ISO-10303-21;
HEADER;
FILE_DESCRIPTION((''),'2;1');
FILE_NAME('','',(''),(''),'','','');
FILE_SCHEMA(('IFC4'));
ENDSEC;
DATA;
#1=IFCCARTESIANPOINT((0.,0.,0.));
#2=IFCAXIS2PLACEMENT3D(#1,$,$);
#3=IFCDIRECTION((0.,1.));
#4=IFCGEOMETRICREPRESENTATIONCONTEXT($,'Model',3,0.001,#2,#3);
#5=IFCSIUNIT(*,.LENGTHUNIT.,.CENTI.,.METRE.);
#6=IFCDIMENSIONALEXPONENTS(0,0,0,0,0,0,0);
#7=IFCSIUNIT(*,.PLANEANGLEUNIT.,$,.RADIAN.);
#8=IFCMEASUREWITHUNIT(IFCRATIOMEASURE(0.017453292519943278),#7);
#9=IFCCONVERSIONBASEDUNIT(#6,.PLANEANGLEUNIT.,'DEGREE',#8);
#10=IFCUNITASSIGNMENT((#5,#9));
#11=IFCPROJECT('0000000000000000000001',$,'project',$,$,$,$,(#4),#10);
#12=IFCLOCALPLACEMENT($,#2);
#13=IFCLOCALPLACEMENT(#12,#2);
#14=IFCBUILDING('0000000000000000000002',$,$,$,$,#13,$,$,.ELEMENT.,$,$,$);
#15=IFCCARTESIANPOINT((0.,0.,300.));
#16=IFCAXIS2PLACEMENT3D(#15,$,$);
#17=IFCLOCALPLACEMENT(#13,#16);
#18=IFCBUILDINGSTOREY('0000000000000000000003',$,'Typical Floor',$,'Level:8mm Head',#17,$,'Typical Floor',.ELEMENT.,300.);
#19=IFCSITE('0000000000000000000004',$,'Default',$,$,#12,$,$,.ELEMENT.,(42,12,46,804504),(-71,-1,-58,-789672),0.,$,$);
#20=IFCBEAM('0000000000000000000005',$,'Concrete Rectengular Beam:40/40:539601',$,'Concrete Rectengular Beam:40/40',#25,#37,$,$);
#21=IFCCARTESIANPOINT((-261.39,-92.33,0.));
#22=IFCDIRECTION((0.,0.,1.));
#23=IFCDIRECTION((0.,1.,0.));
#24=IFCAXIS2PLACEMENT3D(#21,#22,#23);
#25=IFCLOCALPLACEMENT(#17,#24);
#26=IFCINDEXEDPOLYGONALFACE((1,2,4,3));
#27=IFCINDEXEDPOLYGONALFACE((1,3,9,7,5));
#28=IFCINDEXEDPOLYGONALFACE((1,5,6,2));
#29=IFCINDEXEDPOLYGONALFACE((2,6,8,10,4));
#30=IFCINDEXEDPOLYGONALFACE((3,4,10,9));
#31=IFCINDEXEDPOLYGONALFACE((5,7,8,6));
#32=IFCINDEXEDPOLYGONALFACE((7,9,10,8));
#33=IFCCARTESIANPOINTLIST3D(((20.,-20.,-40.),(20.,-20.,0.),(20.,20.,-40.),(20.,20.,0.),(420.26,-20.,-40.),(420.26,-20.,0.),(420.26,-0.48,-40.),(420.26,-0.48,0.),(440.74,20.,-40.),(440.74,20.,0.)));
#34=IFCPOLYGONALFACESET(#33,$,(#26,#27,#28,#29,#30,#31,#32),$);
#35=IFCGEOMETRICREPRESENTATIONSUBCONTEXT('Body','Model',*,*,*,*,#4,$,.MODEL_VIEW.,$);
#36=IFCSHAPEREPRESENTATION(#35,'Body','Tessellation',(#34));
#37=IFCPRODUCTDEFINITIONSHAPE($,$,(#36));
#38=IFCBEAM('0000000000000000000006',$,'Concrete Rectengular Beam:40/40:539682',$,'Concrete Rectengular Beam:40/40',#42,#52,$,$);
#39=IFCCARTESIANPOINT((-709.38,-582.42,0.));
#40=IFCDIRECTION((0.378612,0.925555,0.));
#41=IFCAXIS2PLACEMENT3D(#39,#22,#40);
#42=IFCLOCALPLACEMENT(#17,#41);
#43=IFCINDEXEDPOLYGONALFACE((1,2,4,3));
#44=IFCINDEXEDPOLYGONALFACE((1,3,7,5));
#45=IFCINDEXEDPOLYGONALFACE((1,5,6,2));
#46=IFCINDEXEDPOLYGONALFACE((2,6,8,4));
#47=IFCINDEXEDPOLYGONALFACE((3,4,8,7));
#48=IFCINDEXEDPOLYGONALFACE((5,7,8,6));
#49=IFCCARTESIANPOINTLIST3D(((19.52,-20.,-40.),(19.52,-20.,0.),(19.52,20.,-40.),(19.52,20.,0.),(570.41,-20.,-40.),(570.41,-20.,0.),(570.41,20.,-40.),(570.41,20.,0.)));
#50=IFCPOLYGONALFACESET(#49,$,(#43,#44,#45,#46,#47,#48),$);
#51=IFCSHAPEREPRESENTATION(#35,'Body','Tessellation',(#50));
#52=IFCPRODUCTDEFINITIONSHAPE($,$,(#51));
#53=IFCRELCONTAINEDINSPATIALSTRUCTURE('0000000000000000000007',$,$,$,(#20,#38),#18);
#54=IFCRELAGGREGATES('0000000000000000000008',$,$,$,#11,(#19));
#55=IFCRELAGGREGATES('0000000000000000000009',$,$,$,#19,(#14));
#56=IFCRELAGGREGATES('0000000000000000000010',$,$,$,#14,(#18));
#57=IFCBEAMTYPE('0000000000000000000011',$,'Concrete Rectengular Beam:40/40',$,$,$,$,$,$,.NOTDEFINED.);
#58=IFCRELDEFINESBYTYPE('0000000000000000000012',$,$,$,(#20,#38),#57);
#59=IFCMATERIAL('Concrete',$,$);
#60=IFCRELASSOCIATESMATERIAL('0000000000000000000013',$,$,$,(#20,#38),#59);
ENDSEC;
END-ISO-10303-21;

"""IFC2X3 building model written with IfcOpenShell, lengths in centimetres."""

from ifc_helpers import new_model, entity, si_unit, converted_unit, direction, frame, frame_2d, origin, place, context, subcontext, project, spatial, polyline, rectangle, extrude, clip, bounded_halfspace, material, type_object, element, save


model = new_model("IFC2X3")

# Units and contexts
model_context = context("Model", 3, precision=0.001, world=origin(), true_north=direction((0.0, 1.0)))
body_context = subcontext(model_context, "Body", "Model", "MODEL_VIEW")
ifc_project = project(units=[si_unit("LENGTHUNIT", "METRE", prefix="CENTI"), converted_unit("PLANEANGLEUNIT", "DEGREE", entity("IfcRatioMeasure", 0.017453292519943278), si_unit("PLANEANGLEUNIT", "RADIAN"), dimensions=[0, 0, 0, 0, 0, 0, 0])], contexts=[model_context])

# Site, building, storey
site_placement = place(None, origin())
site = spatial("IfcSite", under=ifc_project, at=site_placement, Name="Default", CompositionType="ELEMENT", RefLatitude=(42, 12, 46, 804504), RefLongitude=(-71, -1, -58, -789672), RefElevation=0.0)
building_placement = place(site_placement, origin())
building = spatial("IfcBuilding", under=site, at=building_placement, CompositionType="ELEMENT")
storey_placement = place(building_placement, frame((0.0, 0.0, 300.0)))
storey = spatial("IfcBuildingStorey", under=building, at=storey_placement, Name="Typical Floor", ObjectType="Level:8mm Head", LongName="Typical Floor", CompositionType="ELEMENT", Elevation=300.0)

# Beams
ifc_material = material(Name="Concrete")
beam_type_1 = type_object("IfcBeamType", Name="Concrete Rectengular Beam:40/40", PredefinedType="NOTDEFINED")
beam_1_placement = place(storey_placement, frame((-261.39, -92.33, 0.0), z_axis=(0.0, 0.0, 1.0), x_axis=(0.0, 1.0, 0.0)))
element("IfcBeam", 1, at=beam_1_placement, inside=storey, type_object=beam_type_1, material=ifc_material, Name="Concrete Rectengular Beam:40/40:539601", ObjectType="Concrete Rectengular Beam:40/40", context=body_context, shape_type="SweptSolid", body=[
    clip(clip(extrude(rectangle(XDim=40.0, YDim=40.0, at=frame_2d((0.0, 0.0), x_axis=(1.0, 0.0))), frame((20.0, 0.0, -20.0), z_axis=(1.0, 0.0, 0.0), x_axis=(0.0, 0.0, -1.0)), (0.0, 0.0, 1.0), 420.74), bounded_halfspace(frame((420.26, -73.77, -300.0), z_axis=(1.0, 0.0, 0.0), x_axis=(0.0, -1.0, 0.0)), False, frame((20.0, 0.0, -20.0), z_axis=(1.0, 0.0, 0.0), x_axis=(0.0, 0.0, -1.0)), polyline([(-20.0, -0.48), (-20.0, -20.0), (0.0, -20.0), (20.0, -20.0), (20.0, -0.48), (-20.0, -0.48)]))), bounded_halfspace(frame((432.58, 11.85, -300.0), z_axis=(0.707107, -0.707107, 0.0), x_axis=(-0.707107, -0.707107, 0.0)), False, frame((20.0, 0.0, -20.0), z_axis=(1.0, 0.0, 0.0), x_axis=(0.0, 0.0, -1.0)), polyline([(-20.0, -0.48), (20.0, -0.48), (20.0, 20.0), (0.0, 20.0), (-20.0, 20.0), (-20.0, -0.48)]))),
])
beam_2_placement = place(storey_placement, frame((-709.38, -582.42, 0.0), z_axis=(0.0, 0.0, 1.0), x_axis=(0.378612, 0.925555, 0.0)))
element("IfcBeam", 2, at=beam_2_placement, inside=storey, type_object=beam_type_1, material=ifc_material, Name="Concrete Rectengular Beam:40/40:539682", ObjectType="Concrete Rectengular Beam:40/40", context=body_context, shape_type="SweptSolid", body=[
    extrude(rectangle(XDim=40.0, YDim=40.0, at=frame_2d((0.0, 0.0), x_axis=(1.0, 0.0))), frame((19.52, 0.0, -20.0), z_axis=(1.0, 0.0, 0.0), x_axis=(0.0, 0.0, -1.0)), (0.0, 0.0, 1.0), 550.89),
])

save(model, "model.ifc")
